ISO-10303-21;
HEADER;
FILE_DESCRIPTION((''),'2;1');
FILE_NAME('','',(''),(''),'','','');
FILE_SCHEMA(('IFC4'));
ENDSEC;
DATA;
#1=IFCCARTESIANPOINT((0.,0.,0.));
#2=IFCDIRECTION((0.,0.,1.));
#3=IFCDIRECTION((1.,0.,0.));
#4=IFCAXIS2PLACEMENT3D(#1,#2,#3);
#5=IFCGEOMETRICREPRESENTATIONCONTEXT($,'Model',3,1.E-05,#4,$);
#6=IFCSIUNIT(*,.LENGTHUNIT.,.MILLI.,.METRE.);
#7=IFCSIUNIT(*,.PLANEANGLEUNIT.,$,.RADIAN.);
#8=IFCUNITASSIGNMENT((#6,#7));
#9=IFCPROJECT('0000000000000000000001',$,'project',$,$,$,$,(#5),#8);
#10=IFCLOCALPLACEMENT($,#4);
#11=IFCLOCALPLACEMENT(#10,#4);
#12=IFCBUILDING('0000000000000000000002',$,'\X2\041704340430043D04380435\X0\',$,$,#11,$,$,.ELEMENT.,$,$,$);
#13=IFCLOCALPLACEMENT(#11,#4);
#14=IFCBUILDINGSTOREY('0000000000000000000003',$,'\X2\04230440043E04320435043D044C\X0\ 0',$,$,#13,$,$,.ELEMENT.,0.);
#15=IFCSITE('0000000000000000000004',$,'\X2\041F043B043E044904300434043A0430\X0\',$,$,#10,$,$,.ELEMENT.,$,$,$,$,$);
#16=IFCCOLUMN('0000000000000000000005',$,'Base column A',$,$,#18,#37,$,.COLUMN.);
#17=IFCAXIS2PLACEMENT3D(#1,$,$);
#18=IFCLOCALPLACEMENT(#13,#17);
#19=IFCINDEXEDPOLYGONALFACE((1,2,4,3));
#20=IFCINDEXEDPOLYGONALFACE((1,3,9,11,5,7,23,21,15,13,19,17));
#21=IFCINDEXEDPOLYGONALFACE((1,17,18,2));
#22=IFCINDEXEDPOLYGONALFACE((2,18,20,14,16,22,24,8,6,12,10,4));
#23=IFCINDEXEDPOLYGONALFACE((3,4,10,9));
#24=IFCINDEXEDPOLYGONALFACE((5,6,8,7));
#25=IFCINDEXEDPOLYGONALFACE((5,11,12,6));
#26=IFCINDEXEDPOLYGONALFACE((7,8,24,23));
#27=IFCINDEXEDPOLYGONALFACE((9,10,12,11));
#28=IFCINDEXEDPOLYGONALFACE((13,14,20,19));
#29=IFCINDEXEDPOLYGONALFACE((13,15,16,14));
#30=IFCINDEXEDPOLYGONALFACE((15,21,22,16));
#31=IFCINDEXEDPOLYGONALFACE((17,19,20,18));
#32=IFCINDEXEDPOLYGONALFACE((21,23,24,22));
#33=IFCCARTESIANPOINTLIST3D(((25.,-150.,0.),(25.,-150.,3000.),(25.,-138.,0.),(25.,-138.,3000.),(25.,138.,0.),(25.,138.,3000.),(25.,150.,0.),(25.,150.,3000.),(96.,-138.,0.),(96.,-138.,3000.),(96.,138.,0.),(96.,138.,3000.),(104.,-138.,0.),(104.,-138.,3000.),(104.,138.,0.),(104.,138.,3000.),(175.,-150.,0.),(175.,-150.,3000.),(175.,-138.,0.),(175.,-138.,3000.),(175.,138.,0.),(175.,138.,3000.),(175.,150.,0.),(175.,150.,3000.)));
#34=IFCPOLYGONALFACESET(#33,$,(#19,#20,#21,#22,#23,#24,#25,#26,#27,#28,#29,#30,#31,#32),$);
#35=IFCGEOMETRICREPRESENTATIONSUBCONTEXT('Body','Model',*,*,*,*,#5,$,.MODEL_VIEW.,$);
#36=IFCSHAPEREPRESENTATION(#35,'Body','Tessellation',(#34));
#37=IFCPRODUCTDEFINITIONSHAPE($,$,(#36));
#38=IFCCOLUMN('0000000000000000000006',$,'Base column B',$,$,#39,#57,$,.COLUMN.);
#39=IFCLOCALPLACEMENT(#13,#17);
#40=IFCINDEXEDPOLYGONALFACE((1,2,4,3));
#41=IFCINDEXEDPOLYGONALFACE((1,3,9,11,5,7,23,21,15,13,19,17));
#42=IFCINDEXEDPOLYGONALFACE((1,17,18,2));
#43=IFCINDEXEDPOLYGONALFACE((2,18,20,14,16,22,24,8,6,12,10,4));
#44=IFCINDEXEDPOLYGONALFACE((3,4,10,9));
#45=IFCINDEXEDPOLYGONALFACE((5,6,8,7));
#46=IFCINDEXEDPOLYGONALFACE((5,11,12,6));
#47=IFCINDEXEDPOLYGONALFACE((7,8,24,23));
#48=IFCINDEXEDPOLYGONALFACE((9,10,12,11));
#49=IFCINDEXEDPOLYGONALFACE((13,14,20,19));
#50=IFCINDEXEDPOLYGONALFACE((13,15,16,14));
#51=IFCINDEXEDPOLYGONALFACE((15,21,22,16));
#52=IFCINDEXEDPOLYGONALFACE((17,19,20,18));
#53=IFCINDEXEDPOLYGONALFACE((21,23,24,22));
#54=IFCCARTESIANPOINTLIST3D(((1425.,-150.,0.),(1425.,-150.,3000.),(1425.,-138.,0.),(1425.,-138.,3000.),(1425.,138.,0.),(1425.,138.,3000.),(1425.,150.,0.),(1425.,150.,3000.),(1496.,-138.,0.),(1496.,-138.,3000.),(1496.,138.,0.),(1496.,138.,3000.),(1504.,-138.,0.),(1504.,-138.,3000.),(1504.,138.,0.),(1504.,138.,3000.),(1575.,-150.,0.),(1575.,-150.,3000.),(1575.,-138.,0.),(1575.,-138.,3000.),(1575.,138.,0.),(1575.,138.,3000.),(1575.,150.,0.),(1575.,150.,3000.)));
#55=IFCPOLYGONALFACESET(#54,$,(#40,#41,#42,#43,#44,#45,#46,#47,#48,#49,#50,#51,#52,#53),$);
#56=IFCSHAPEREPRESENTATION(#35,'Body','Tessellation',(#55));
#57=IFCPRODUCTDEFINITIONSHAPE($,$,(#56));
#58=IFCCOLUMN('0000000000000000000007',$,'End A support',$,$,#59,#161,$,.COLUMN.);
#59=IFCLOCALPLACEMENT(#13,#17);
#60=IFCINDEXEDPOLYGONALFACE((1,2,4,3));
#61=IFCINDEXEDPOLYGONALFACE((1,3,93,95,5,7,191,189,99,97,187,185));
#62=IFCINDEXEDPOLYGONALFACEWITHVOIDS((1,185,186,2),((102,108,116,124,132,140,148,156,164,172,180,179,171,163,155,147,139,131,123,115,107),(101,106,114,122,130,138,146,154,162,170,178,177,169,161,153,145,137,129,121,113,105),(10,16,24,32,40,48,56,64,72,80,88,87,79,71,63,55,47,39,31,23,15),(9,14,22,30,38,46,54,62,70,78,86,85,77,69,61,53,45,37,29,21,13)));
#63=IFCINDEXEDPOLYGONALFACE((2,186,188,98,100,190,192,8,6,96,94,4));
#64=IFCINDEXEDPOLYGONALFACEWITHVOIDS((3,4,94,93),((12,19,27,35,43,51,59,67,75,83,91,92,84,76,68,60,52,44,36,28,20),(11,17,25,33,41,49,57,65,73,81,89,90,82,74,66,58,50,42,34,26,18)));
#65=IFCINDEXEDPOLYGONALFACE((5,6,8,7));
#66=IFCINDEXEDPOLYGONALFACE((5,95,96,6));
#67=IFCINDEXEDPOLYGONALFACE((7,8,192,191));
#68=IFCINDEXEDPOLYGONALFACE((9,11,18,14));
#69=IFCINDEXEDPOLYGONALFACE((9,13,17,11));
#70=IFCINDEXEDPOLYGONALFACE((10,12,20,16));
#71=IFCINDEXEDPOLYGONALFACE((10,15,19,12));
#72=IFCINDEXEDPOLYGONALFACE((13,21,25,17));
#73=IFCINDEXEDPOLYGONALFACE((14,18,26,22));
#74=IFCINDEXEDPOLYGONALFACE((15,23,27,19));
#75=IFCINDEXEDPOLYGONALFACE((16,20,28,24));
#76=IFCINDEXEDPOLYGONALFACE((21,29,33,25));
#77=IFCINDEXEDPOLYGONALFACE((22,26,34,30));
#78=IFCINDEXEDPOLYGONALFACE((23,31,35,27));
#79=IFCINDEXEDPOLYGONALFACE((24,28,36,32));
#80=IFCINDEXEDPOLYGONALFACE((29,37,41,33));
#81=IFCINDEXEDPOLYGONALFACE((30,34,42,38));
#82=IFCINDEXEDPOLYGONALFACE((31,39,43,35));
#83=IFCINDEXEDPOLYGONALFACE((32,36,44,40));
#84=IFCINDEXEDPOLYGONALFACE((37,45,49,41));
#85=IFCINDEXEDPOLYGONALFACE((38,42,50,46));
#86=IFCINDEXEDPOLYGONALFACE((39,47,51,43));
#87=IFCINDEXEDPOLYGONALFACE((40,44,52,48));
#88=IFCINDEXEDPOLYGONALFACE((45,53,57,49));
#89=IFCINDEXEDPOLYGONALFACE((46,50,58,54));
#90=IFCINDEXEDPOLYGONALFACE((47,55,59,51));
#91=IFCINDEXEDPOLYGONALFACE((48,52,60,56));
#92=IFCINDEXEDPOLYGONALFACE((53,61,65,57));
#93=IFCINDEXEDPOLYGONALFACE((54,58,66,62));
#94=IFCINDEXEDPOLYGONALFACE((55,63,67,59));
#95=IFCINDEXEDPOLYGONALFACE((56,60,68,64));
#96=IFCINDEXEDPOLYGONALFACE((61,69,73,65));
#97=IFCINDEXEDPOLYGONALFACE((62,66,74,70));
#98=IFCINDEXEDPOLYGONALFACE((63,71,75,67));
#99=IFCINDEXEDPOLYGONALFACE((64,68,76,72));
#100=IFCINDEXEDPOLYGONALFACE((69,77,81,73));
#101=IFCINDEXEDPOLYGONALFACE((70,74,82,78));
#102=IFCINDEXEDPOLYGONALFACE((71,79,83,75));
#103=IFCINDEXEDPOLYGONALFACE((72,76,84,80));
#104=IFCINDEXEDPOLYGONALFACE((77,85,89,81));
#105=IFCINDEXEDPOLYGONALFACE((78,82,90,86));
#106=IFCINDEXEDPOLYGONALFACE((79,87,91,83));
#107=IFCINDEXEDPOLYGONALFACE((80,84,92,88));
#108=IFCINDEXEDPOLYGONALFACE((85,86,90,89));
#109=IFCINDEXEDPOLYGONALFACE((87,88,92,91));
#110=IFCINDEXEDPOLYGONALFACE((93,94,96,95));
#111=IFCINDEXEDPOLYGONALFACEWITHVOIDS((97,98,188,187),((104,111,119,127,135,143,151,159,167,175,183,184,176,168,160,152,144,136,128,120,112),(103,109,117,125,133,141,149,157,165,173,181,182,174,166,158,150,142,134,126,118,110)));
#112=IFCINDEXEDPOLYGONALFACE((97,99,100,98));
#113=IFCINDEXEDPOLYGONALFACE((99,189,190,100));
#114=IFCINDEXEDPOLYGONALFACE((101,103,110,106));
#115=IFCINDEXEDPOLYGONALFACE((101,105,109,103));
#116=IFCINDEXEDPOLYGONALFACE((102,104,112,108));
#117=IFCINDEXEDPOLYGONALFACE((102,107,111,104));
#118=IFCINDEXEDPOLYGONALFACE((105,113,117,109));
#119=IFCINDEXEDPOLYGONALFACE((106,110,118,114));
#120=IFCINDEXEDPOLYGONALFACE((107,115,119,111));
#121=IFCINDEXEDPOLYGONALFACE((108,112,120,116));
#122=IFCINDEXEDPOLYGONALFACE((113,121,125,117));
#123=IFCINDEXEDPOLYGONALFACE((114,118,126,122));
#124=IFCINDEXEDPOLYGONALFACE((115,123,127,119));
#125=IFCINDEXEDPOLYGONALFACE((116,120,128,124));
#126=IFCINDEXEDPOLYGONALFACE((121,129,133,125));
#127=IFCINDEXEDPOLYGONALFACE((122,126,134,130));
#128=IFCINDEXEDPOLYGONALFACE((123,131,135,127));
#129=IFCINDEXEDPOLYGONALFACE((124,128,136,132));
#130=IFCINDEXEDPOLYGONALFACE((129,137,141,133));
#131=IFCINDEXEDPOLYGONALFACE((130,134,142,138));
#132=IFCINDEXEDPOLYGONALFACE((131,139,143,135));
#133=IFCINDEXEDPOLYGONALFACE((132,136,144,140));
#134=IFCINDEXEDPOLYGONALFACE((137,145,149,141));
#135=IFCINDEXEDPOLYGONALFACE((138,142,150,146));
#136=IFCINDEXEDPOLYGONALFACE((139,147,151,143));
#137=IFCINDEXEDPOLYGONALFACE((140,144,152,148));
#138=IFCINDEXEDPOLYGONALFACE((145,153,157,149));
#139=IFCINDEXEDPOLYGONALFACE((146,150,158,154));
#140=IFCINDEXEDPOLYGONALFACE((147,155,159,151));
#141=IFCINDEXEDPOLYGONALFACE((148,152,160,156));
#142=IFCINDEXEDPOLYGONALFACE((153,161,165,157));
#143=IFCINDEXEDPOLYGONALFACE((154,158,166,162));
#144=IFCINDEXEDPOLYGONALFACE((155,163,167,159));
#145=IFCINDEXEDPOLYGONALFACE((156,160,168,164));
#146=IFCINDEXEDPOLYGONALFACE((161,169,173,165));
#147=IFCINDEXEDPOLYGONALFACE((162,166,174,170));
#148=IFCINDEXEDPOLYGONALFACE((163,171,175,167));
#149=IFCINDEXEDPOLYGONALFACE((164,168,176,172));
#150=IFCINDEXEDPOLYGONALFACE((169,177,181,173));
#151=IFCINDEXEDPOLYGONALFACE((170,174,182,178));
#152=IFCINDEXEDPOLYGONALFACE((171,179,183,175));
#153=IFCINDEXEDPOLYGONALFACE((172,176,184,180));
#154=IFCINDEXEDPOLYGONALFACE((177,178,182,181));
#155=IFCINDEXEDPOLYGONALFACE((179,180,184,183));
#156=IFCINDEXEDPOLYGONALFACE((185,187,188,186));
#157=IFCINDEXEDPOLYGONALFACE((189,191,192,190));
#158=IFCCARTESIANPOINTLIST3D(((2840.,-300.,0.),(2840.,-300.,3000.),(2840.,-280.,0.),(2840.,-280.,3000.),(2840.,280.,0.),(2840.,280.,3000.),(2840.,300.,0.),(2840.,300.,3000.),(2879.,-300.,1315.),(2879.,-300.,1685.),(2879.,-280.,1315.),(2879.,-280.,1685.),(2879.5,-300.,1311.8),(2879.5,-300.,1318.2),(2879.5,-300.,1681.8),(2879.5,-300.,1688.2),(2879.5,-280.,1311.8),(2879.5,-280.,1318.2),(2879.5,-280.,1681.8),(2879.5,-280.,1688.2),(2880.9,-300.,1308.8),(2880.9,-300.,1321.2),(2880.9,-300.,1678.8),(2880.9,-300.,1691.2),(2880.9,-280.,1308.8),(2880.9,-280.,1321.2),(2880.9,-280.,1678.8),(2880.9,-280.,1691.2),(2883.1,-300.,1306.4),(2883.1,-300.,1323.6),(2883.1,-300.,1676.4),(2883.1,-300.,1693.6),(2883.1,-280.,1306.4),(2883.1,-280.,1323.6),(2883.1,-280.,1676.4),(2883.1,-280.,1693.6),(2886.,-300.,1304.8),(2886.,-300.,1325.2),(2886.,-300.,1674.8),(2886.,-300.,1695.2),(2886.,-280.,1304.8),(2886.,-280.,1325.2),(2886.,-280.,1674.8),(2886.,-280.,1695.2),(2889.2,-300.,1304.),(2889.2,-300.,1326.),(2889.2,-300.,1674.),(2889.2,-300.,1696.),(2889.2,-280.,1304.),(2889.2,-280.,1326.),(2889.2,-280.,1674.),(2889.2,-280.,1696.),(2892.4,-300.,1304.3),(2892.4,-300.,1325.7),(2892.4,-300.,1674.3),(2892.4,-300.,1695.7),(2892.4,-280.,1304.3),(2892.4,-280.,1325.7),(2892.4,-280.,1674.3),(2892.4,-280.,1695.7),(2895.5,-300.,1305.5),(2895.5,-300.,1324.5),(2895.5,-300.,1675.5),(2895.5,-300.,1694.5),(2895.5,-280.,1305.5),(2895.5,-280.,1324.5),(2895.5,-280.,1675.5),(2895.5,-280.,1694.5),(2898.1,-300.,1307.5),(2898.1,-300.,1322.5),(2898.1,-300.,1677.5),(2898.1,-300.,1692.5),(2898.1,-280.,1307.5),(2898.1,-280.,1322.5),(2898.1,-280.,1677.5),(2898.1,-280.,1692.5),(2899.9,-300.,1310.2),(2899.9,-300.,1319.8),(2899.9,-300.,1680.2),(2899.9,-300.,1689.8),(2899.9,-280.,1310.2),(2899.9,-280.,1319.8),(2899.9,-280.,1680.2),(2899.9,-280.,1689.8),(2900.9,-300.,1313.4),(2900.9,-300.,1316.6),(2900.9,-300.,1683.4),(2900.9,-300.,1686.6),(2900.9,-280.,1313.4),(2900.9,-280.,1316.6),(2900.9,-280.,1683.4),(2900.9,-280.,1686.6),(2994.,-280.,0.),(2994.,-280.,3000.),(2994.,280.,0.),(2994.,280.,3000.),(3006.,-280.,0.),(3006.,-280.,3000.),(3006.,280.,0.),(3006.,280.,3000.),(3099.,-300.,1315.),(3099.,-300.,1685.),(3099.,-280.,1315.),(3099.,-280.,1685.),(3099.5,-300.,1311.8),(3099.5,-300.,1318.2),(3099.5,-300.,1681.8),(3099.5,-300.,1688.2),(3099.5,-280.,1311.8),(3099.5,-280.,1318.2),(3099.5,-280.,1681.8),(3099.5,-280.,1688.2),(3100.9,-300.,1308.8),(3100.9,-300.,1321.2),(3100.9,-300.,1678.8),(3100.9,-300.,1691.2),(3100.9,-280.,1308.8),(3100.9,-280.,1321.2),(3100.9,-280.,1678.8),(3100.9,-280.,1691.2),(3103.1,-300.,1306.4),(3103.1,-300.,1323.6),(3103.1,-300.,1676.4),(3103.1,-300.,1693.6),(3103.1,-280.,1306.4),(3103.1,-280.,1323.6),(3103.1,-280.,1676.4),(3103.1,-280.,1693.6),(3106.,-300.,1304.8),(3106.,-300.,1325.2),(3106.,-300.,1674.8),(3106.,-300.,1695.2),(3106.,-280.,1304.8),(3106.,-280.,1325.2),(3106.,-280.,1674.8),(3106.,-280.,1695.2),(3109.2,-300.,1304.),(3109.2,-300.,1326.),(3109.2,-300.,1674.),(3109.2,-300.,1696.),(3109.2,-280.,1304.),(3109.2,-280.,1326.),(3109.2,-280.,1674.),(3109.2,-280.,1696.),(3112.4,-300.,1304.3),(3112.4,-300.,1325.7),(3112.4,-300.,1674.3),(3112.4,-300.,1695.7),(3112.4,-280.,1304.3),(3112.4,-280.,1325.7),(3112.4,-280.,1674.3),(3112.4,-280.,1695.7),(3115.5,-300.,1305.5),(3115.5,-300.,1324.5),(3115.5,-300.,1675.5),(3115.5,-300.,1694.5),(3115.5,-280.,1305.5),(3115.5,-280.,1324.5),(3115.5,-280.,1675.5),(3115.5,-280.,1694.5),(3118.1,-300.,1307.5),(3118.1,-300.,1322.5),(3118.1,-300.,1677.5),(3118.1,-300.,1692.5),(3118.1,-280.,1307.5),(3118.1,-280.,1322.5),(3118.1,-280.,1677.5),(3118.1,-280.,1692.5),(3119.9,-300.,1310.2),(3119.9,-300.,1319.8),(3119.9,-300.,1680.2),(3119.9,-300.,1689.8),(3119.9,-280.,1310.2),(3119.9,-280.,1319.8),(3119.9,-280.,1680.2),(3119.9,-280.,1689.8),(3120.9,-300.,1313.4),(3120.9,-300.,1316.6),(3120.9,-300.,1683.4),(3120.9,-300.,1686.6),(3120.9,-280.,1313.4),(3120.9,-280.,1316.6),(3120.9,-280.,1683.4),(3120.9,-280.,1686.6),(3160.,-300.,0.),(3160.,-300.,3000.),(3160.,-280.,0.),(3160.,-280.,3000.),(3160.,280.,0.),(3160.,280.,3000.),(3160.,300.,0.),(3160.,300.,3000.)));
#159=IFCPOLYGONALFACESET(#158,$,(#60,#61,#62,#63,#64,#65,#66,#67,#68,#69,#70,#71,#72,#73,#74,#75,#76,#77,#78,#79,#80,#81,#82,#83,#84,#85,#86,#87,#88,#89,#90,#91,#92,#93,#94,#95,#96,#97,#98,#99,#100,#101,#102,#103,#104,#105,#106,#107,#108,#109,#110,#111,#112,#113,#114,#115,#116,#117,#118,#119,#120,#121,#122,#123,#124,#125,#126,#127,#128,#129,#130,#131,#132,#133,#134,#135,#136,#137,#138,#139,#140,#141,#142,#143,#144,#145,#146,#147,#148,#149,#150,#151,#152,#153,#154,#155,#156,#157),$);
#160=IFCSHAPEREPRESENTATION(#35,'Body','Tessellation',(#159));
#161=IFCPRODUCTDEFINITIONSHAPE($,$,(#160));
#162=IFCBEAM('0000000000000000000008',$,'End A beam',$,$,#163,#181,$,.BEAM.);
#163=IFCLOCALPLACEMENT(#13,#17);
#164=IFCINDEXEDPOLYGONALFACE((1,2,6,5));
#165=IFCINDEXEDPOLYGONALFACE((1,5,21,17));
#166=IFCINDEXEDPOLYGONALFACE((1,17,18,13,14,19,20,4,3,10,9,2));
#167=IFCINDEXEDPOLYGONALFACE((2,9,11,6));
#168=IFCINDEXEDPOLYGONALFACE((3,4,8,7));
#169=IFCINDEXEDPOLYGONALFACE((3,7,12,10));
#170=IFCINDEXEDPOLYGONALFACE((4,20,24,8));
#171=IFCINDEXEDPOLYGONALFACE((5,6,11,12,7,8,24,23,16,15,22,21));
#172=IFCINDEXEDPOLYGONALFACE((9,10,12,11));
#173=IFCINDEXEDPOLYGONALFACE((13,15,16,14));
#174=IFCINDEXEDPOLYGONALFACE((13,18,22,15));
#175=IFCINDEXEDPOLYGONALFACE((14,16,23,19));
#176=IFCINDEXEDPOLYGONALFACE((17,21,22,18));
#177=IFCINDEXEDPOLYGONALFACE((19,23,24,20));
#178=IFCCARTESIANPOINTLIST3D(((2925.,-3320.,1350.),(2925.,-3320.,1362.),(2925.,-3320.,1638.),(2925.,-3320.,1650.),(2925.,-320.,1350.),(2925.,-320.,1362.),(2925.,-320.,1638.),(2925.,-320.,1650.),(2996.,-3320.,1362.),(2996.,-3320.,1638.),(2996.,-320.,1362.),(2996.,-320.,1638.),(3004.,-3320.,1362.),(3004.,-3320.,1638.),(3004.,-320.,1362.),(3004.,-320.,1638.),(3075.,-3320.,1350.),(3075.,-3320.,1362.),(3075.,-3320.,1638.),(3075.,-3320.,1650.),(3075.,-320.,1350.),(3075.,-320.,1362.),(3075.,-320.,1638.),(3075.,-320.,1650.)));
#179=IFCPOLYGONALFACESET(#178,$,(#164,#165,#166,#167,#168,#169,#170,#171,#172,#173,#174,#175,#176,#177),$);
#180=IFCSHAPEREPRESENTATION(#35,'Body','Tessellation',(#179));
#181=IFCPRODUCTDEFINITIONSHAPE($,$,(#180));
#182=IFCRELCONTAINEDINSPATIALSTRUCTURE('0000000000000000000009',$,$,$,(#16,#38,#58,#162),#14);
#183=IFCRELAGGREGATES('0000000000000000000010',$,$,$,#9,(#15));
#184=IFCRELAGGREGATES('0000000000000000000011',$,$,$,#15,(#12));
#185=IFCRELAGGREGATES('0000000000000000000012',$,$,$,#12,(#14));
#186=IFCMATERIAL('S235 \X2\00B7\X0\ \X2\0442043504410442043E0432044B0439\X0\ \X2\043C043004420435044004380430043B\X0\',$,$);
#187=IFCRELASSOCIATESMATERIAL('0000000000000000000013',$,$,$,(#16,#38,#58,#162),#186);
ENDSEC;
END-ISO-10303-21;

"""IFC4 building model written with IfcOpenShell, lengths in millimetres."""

from ifc_helpers import new_model, si_unit, frame, origin_with_axes, place, context, subcontext, project, spatial, circle, i_section, extrude, material, element, save


model = new_model("IFC4")

# Units and contexts
model_context = context("Model", 3, precision=1e-05, world=origin_with_axes())
body_context = subcontext(model_context, "Body", "Model", "MODEL_VIEW")
ifc_project = project(units=[si_unit("LENGTHUNIT", "METRE", prefix="MILLI"), si_unit("PLANEANGLEUNIT", "RADIAN")], contexts=[model_context])

# Site, building, storey
site_placement = place(None, origin_with_axes())
site = spatial("IfcSite", under=ifc_project, at=site_placement, Name="Площадка", CompositionType="ELEMENT")
building_placement = place(site_placement, origin_with_axes())
building = spatial("IfcBuilding", under=site, at=building_placement, Name="Здание", CompositionType="ELEMENT")
storey_placement = place(building_placement, origin_with_axes())
storey = spatial("IfcBuildingStorey", under=building, at=storey_placement, Name="Уровень 0", CompositionType="ELEMENT", Elevation=0.0)

# Columns
ifc_material = material(Name="S235 · тестовый материал")
for number, where, z_axis, x_axis, name in (
    (1, (100.0, 0.0, 0.0), (0.0, 0.0, 1.0), (1.0, 0.0, 0.0), "Base column A"),
    (2, (1500.0, 0.0, 0.0), (0.0, 0.0, 1.0), (1.0, 0.0, 0.0), "Base column B"),
):
    element("IfcColumn", number, at=place(storey_placement, frame(where, z_axis=z_axis, x_axis=x_axis)), inside=storey, material=ifc_material, Name=name, PredefinedType="COLUMN", context=body_context, shape_type="SweptSolid", body=[
        extrude(i_section(OverallWidth=150.0, OverallDepth=300.0, WebThickness=8.0, FlangeThickness=12.0), origin_with_axes(), (0.0, 0.0, 1.0), 3000.0),
    ])

# Column, openings
column_placement = place(storey_placement, frame((3000.0, 0.0, 0.0), z_axis=(0.0, 0.0, 1.0), x_axis=(1.0, 0.0, 0.0)))
column = element("IfcColumn", 3, at=column_placement, inside=storey, material=ifc_material, Name="End A support", PredefinedType="COLUMN", context=body_context, shape_type="SweptSolid", body=[
    extrude(i_section(OverallWidth=320.0, OverallDepth=600.0, WebThickness=12.0, FlangeThickness=20.0), origin_with_axes(), (0.0, 0.0, 1.0), 3000.0),
])
opening_1_placement = place(column_placement, frame((110.0, -321.0, 1315.0), z_axis=(0.0, 1.0, 0.0), x_axis=(-1.0, 0.0, 0.0)))
element("IfcOpeningElement", 4, at=opening_1_placement, cuts=column, PredefinedType="OPENING", context=body_context, shape_type="SweptSolid", body=[
    extrude(circle(Radius=11.0), origin_with_axes(), (0.0, 0.0, 1.0), 42.0),
])
opening_2_placement = place(column_placement, frame((110.0, -321.0, 1685.0), z_axis=(0.0, 1.0, 0.0), x_axis=(-1.0, 0.0, 0.0)))
element("IfcOpeningElement", 5, at=opening_2_placement, cuts=column, PredefinedType="OPENING", context=body_context, shape_type="SweptSolid", body=[
    extrude(circle(Radius=11.0), origin_with_axes(), (0.0, 0.0, 1.0), 42.0),
])
opening_3_placement = place(column_placement, frame((-110.0, -321.0, 1315.0), z_axis=(0.0, 1.0, 0.0), x_axis=(-1.0, 0.0, 0.0)))
element("IfcOpeningElement", 6, at=opening_3_placement, cuts=column, PredefinedType="OPENING", context=body_context, shape_type="SweptSolid", body=[
    extrude(circle(Radius=11.0), origin_with_axes(), (0.0, 0.0, 1.0), 42.0),
])
opening_4_placement = place(column_placement, frame((-110.0, -321.0, 1685.0), z_axis=(0.0, 1.0, 0.0), x_axis=(-1.0, 0.0, 0.0)))
element("IfcOpeningElement", 7, at=opening_4_placement, cuts=column, PredefinedType="OPENING", context=body_context, shape_type="SweptSolid", body=[
    extrude(circle(Radius=11.0), origin_with_axes(), (0.0, 0.0, 1.0), 42.0),
])

# Beam
beam_1_placement = place(storey_placement, frame((3000.0, -3320.0, 1500.0), z_axis=(0.0, 1.0, 0.0), x_axis=(-1.0, 0.0, 0.0)))
element("IfcBeam", 8, at=beam_1_placement, inside=storey, material=ifc_material, Name="End A beam", PredefinedType="BEAM", context=body_context, shape_type="SweptSolid", body=[
    extrude(i_section(OverallWidth=150.0, OverallDepth=300.0, WebThickness=8.0, FlangeThickness=12.0), origin_with_axes(), (0.0, 0.0, 1.0), 3000.0),
])

save(model, "model.ifc")
